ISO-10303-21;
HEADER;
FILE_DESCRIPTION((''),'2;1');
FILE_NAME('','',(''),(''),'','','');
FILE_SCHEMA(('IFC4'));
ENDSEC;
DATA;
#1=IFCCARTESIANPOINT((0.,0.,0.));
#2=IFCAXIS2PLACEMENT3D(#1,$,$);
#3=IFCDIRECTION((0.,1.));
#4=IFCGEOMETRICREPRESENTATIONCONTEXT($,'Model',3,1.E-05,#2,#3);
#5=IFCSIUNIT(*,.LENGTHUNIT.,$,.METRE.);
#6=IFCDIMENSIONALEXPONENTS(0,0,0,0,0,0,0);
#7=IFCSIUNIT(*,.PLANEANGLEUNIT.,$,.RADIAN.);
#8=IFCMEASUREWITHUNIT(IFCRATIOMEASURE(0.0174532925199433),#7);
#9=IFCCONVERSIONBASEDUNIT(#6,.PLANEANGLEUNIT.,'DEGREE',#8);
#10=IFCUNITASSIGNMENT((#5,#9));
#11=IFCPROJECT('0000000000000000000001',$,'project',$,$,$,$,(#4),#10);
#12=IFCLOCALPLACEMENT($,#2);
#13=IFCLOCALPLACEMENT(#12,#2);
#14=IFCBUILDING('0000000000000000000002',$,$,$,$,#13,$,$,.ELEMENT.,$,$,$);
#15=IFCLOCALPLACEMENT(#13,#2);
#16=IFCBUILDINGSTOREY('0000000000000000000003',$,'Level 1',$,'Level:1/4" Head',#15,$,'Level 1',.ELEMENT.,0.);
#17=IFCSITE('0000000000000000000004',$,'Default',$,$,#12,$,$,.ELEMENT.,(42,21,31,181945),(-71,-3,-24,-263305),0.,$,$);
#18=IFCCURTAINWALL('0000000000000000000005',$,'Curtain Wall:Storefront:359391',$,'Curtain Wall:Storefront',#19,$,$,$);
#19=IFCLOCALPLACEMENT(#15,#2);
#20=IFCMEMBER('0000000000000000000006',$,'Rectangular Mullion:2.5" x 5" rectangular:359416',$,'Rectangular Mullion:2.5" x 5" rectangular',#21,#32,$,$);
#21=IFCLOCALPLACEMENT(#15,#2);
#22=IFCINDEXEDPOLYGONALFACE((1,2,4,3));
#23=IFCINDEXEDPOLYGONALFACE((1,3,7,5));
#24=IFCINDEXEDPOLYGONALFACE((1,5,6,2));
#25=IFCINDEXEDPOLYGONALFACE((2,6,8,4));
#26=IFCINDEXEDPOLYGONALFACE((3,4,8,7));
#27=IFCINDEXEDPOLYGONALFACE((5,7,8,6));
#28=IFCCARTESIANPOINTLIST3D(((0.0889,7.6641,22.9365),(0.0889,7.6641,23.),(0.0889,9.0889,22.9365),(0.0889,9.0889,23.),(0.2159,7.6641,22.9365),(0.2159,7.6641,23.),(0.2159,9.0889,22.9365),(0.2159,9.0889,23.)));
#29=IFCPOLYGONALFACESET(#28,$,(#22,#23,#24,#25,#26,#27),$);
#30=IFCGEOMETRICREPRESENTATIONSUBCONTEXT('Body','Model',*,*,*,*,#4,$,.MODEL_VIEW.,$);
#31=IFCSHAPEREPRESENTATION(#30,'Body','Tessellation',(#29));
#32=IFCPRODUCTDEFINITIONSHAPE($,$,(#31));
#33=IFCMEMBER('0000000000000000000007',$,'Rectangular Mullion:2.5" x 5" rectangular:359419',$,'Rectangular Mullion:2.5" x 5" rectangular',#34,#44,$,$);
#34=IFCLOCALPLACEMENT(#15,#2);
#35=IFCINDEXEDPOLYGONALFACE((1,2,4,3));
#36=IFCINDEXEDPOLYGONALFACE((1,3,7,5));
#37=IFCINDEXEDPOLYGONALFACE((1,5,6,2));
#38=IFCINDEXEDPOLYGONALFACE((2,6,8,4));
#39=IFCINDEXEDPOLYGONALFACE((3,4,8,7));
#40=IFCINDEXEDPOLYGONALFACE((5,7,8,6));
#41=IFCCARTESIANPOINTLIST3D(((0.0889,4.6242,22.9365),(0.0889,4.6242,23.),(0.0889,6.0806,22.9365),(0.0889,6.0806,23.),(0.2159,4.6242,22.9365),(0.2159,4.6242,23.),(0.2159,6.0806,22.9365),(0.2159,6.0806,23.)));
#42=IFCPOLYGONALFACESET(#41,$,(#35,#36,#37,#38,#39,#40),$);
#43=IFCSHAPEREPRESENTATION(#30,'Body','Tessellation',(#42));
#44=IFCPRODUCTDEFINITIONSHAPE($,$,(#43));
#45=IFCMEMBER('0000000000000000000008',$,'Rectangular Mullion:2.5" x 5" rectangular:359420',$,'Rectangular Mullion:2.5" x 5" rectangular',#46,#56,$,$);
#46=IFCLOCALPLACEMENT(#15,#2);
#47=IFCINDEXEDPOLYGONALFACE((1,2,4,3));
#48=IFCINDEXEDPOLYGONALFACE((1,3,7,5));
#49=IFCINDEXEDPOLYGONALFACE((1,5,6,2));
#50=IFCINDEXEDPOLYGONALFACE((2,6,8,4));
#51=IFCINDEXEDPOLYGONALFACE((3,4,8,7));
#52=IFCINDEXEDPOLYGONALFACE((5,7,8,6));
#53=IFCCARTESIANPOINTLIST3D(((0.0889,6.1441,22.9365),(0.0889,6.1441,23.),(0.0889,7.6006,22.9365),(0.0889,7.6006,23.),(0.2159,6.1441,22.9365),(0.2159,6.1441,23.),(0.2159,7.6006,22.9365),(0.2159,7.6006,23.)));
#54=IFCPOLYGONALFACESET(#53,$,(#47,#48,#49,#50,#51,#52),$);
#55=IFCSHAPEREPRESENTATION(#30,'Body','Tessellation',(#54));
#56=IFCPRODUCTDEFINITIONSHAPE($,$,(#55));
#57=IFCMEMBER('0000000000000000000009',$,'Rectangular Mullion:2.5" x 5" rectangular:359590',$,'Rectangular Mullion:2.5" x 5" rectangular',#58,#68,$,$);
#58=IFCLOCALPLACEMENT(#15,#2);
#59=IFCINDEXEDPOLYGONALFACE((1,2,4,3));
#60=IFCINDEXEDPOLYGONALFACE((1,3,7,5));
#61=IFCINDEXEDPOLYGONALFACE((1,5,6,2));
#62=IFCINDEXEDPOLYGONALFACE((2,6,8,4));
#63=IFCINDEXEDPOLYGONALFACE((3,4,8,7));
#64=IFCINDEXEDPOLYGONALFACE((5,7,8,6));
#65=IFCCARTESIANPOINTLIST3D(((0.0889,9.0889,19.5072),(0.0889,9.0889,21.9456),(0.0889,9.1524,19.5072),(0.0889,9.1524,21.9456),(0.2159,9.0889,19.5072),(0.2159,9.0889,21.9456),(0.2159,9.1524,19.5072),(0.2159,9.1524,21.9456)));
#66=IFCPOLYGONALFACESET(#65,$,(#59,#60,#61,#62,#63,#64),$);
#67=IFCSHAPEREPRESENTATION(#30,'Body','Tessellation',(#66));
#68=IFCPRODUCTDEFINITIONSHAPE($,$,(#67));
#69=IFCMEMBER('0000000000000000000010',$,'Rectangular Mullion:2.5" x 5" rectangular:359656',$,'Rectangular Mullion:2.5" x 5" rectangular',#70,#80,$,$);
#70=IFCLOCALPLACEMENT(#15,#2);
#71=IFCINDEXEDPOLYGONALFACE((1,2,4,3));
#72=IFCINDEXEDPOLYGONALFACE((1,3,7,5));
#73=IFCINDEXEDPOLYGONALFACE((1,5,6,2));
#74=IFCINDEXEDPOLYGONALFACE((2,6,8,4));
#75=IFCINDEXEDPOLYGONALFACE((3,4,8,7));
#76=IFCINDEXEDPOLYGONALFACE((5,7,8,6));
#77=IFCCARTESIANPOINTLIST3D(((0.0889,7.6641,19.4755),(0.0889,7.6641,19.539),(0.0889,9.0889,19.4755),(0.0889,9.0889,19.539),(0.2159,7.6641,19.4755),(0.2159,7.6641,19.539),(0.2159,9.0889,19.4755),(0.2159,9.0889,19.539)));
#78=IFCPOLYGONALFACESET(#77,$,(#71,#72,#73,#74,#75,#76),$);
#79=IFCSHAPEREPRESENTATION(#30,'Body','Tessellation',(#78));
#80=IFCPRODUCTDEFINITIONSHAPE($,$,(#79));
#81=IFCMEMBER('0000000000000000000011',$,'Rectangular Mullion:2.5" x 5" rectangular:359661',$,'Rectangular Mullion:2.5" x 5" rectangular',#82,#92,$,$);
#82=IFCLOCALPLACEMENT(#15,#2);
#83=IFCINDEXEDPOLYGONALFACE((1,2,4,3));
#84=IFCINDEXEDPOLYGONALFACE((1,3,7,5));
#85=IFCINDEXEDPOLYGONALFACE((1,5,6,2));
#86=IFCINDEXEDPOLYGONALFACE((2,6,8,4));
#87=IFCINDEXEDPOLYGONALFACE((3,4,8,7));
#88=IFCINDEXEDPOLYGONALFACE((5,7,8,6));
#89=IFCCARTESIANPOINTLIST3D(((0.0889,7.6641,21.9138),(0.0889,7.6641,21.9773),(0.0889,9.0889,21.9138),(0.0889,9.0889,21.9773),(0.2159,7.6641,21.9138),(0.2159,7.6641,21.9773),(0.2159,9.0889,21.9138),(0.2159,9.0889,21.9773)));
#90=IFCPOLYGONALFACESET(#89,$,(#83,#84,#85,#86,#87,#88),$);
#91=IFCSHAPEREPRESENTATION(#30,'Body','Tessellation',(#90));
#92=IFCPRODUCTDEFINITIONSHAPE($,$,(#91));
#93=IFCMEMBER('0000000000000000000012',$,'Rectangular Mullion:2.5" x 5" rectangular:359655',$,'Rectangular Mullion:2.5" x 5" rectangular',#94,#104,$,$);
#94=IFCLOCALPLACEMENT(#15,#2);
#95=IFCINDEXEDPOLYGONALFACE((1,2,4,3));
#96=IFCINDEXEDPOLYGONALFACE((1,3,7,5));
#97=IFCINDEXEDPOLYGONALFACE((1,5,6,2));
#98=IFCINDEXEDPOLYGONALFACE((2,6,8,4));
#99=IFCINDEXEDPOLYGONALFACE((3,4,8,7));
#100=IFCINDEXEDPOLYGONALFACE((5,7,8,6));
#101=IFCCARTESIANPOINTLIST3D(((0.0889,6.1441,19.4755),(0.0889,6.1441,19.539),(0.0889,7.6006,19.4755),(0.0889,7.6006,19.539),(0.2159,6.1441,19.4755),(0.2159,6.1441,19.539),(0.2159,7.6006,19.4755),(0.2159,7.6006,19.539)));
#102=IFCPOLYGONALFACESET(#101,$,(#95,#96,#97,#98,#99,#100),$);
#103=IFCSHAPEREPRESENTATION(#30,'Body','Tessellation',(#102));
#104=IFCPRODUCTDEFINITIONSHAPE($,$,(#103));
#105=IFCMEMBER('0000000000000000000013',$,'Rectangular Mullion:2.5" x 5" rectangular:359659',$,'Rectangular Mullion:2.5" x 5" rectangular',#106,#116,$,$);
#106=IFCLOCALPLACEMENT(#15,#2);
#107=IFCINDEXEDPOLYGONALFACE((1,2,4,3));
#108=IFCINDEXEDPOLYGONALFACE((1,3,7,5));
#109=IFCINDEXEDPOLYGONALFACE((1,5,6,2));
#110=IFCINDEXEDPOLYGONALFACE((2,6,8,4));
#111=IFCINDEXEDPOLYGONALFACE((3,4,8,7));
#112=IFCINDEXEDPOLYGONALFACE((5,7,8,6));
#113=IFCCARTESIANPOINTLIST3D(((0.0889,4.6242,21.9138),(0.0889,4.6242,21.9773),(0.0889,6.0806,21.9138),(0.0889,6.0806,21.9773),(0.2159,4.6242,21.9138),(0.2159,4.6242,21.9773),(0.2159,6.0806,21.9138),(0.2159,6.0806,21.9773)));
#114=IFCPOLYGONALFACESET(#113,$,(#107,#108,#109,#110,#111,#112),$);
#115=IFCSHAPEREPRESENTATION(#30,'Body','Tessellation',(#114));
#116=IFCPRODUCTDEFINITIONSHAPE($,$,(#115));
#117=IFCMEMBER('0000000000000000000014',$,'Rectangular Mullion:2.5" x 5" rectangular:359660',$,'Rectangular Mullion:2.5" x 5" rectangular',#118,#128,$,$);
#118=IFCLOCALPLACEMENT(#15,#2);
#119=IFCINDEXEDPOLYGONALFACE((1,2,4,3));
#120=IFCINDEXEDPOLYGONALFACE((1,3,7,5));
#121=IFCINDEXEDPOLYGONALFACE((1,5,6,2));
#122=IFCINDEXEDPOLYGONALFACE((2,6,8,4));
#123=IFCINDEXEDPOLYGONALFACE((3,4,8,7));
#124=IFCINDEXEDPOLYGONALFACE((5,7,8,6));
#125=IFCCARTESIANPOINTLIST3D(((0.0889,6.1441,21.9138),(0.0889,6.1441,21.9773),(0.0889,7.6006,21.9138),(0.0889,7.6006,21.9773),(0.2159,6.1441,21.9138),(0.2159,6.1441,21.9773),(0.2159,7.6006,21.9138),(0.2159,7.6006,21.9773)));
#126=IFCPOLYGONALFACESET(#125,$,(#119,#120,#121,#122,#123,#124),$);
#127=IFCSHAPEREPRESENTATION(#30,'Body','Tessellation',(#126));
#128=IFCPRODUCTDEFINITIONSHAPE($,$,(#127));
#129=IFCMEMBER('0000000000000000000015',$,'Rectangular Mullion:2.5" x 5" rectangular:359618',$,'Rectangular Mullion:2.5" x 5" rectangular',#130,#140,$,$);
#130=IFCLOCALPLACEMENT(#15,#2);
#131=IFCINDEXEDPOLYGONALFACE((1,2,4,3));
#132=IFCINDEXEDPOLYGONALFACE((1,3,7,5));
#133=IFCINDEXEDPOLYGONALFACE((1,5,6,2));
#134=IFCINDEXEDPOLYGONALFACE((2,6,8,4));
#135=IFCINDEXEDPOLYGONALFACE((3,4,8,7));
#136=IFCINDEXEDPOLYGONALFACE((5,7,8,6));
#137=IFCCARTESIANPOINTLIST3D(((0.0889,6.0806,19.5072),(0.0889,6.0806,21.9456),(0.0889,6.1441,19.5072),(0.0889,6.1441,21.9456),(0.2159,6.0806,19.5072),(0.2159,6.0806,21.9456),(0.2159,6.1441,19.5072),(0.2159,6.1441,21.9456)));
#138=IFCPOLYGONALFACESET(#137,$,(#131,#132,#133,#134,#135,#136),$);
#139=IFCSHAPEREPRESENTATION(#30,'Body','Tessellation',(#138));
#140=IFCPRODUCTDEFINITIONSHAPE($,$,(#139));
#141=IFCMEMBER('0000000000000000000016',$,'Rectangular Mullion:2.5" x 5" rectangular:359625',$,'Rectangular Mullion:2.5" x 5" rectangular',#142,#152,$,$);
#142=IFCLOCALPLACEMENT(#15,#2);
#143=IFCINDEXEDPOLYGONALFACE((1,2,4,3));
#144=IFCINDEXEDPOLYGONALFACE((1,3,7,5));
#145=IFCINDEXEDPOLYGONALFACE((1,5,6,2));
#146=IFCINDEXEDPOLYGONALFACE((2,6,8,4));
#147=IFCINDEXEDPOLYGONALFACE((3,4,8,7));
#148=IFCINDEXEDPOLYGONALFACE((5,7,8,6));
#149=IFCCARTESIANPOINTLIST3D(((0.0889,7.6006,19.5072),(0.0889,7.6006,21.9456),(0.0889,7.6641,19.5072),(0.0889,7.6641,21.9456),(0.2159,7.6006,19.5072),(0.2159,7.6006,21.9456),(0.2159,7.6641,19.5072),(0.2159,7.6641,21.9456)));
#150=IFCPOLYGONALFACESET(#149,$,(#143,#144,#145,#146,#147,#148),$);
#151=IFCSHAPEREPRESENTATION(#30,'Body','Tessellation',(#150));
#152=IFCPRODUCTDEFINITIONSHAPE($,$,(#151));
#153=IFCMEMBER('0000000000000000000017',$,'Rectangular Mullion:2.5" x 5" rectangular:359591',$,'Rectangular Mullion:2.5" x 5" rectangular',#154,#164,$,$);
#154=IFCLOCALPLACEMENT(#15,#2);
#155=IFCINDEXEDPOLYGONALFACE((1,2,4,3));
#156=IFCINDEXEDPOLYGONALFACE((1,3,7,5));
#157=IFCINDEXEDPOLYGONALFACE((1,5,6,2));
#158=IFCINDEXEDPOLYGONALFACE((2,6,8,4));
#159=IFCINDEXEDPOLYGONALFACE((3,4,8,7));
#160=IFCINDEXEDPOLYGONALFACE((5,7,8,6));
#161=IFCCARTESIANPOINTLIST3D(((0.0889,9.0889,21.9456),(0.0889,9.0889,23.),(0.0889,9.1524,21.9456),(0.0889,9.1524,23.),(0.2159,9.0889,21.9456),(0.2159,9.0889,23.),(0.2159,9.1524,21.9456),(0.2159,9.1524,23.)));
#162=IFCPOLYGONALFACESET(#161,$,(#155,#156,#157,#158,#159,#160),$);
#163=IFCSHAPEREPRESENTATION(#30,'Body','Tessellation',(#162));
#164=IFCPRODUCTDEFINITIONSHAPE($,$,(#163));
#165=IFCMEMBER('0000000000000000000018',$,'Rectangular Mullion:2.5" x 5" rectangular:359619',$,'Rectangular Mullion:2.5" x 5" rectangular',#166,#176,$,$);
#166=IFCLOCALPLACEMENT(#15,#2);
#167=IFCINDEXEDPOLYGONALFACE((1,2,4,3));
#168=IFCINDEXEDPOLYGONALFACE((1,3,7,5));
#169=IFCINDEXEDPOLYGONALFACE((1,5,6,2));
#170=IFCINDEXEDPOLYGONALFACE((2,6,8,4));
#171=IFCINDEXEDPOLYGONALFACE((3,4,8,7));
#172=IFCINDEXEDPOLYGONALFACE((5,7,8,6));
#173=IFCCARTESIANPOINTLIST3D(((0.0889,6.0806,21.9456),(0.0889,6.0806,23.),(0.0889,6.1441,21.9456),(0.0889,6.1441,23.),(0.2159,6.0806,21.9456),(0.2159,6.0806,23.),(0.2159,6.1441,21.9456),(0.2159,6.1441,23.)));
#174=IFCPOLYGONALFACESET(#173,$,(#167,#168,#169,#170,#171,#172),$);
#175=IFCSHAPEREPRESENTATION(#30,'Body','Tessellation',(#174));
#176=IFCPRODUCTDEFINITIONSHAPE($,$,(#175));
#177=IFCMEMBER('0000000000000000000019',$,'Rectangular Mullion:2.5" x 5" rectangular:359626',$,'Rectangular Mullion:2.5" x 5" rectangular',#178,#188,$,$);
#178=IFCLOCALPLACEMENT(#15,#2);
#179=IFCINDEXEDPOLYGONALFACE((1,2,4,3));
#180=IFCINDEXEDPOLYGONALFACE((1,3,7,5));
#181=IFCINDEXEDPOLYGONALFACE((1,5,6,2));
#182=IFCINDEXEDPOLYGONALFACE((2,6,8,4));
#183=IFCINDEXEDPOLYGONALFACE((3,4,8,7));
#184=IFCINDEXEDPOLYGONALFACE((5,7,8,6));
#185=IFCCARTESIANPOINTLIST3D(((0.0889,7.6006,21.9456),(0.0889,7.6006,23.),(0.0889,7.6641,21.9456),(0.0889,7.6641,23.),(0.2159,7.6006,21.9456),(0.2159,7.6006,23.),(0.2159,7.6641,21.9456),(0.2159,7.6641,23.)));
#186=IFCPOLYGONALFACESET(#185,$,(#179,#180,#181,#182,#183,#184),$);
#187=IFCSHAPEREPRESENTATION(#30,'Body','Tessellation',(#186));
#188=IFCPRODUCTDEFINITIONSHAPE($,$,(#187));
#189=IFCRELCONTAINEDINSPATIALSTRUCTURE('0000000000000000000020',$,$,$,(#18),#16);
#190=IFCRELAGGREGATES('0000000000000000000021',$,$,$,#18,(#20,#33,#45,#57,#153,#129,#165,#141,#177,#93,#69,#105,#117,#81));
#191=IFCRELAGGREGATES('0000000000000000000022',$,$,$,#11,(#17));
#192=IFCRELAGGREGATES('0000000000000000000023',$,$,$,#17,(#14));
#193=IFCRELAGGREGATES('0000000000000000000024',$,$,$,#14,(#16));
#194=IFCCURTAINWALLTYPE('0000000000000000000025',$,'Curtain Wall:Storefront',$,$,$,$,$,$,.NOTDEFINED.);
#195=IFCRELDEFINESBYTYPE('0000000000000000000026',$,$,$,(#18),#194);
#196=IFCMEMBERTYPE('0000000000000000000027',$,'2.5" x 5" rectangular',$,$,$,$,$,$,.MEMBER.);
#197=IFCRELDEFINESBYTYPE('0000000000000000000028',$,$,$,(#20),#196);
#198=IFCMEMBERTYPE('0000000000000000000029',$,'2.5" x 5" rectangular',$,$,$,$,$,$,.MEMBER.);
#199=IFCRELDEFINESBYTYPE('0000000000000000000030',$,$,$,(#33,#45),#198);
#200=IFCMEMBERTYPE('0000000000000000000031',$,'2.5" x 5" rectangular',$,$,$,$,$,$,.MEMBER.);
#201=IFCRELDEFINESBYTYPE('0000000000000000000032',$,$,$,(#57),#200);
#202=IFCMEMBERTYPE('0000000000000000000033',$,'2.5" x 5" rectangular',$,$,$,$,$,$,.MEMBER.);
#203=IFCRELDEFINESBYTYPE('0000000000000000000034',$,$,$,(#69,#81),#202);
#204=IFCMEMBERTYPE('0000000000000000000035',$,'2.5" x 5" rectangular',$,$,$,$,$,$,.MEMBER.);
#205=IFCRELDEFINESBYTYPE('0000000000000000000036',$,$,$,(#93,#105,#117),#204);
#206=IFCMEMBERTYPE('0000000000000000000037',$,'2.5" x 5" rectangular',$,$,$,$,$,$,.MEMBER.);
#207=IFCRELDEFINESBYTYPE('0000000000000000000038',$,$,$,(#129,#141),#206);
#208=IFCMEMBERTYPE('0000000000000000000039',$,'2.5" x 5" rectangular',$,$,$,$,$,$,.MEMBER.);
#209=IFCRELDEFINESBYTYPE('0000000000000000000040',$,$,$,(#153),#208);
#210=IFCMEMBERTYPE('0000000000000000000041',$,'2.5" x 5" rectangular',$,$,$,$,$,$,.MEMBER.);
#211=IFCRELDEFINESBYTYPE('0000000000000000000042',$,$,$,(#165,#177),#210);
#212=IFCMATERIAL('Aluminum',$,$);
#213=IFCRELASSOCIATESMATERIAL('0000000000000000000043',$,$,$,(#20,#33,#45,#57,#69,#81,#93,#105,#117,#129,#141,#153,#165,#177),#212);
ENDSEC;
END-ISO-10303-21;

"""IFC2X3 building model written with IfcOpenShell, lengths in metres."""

from ifc_helpers import new_model, entity, si_unit, converted_unit, direction, frame, origin, origin_2d_with_axis, place, context, subcontext, project, spatial, rectangle, extrude, source, transform, mapped, material, type_object, type_shapes, element, aggregate, save


model = new_model("IFC2X3")

# Units and contexts
model_context = context("Model", 3, precision=1e-05, world=origin(), true_north=direction((0.0, 1.0)))
body_context = subcontext(model_context, "Body", "Model", "MODEL_VIEW")
ifc_project = project(units=[si_unit("LENGTHUNIT", "METRE"), converted_unit("PLANEANGLEUNIT", "DEGREE", entity("IfcRatioMeasure", 0.0174532925199433), si_unit("PLANEANGLEUNIT", "RADIAN"), dimensions=[0, 0, 0, 0, 0, 0, 0])], contexts=[model_context])

# Site, building, storey
site_placement = place(None, origin())
site = spatial("IfcSite", under=ifc_project, at=site_placement, Name="Default", CompositionType="ELEMENT", RefLatitude=(42, 21, 31, 181945), RefLongitude=(-71, -3, -24, -263305), RefElevation=0.0)
building_placement = place(site_placement, origin())
building = spatial("IfcBuilding", under=site, at=building_placement, CompositionType="ELEMENT")
storey_placement = place(building_placement, origin())
storey = spatial("IfcBuildingStorey", under=building, at=storey_placement, Name="Level 1", ObjectType="Level:1/4\" Head", LongName="Level 1", CompositionType="ELEMENT", Elevation=0.0)

# Curtain wall, members
curtain_wall_type = type_object("IfcCurtainWallType", Name="Curtain Wall:Storefront", PredefinedType="NOTDEFINED")
curtain_wall_placement = place(storey_placement, origin())
curtain_wall = element("IfcCurtainWall", 1, at=curtain_wall_placement, inside=storey, type_object=curtain_wall_type, Name="Curtain Wall:Storefront:359391", ObjectType="Curtain Wall:Storefront")
ifc_material_1 = material(Name="Aluminum")
member_type_1 = type_object("IfcMemberType", Name="2.5\" x 5\" rectangular", PredefinedType="MEMBER")
shared_shape_1 = source(origin(), body_context, "Body", "SweptSolid", [
    extrude(rectangle(XDim=0.127, YDim=0.0635, at=origin_2d_with_axis()), frame((-0.0318, 0.0, -1.4248), z_axis=(0.0, 0.0, 1.0), x_axis=(0.0, -1.0, 0.0)), (0.0, 0.0, 1.0), 1.4248),
])
type_shapes(member_type_1, [shared_shape_1])
member_1_placement = place(storey_placement, frame((0.1524, 9.0889, 23.0), z_axis=(0.0, 1.0, 0.0), x_axis=(0.0, 0.0, 1.0)))
member_1 = element("IfcMember", 2, at=member_1_placement, type_object=member_type_1, material=ifc_material_1, Name="Rectangular Mullion:2.5\" x 5\" rectangular:359416", ObjectType="Rectangular Mullion:2.5\" x 5\" rectangular", context=body_context, shape_type="MappedRepresentation", body=[
    mapped(shared_shape_1, transform((0.0, 0.0, 0.0), scale=1.0)),
])
member_type_2 = type_object("IfcMemberType", Name="2.5\" x 5\" rectangular", PredefinedType="MEMBER")
shared_shape_2 = source(origin(), body_context, "Body", "SweptSolid", [
    extrude(rectangle(XDim=0.127, YDim=0.0635, at=origin_2d_with_axis()), frame((-0.0318, 0.0, -1.4565), z_axis=(0.0, 0.0, 1.0), x_axis=(0.0, -1.0, 0.0)), (0.0, 0.0, 1.0), 1.4565),
])
type_shapes(member_type_2, [shared_shape_2])
member_2_placement = place(storey_placement, frame((0.1524, 6.0806, 23.0), z_axis=(0.0, 1.0, 0.0), x_axis=(0.0, 0.0, 1.0)))
member_2 = element("IfcMember", 3, at=member_2_placement, type_object=member_type_2, material=ifc_material_1, Name="Rectangular Mullion:2.5\" x 5\" rectangular:359419", ObjectType="Rectangular Mullion:2.5\" x 5\" rectangular", context=body_context, shape_type="MappedRepresentation", body=[
    mapped(shared_shape_2, transform((0.0, 0.0, 0.0), scale=1.0)),
])
member_3_placement = place(storey_placement, frame((0.1524, 7.6006, 23.0), z_axis=(0.0, 1.0, 0.0), x_axis=(0.0, 0.0, 1.0)))
member_3 = element("IfcMember", 4, at=member_3_placement, type_object=member_type_2, material=ifc_material_1, Name="Rectangular Mullion:2.5\" x 5\" rectangular:359420", ObjectType="Rectangular Mullion:2.5\" x 5\" rectangular", context=body_context, shape_type="MappedRepresentation", body=[
    mapped(shared_shape_2, transform((0.0, 0.0, 0.0), scale=1.0)),
])
member_type_3 = type_object("IfcMemberType", Name="2.5\" x 5\" rectangular", PredefinedType="MEMBER")
shared_shape_3 = source(origin(), body_context, "Body", "SweptSolid", [
    extrude(rectangle(XDim=0.127, YDim=0.0635, at=origin_2d_with_axis()), frame((-0.0318, 0.0, -2.4384), z_axis=(0.0, 0.0, 1.0), x_axis=(0.0, -1.0, 0.0)), (0.0, 0.0, 1.0), 2.4384),
])
type_shapes(member_type_3, [shared_shape_3])
member_4_placement = place(storey_placement, frame((0.1524, 9.1524, 19.5072), z_axis=(0.0, 0.0, -1.0), x_axis=(0.0, 1.0, 0.0)))
member_4 = element("IfcMember", 5, at=member_4_placement, type_object=member_type_3, material=ifc_material_1, Name="Rectangular Mullion:2.5\" x 5\" rectangular:359590", ObjectType="Rectangular Mullion:2.5\" x 5\" rectangular", context=body_context, shape_type="MappedRepresentation", body=[
    mapped(shared_shape_3, transform((0.0, 0.0, 0.0), scale=1.0)),
])
member_type_4 = type_object("IfcMemberType", Name="2.5\" x 5\" rectangular", PredefinedType="MEMBER")
shared_shape_4 = source(origin(), body_context, "Body", "SweptSolid", [
    extrude(rectangle(XDim=0.127, YDim=0.0635, at=origin_2d_with_axis()), frame((0.0, 0.0, -1.4248), z_axis=(0.0, 0.0, 1.0), x_axis=(0.0, -1.0, 0.0)), (0.0, 0.0, 1.0), 1.4248),
])
type_shapes(member_type_4, [shared_shape_4])
member_5_placement = place(storey_placement, frame((0.1524, 9.0889, 19.5072), z_axis=(0.0, 1.0, 0.0), x_axis=(0.0, 0.0, 1.0)))
member_5 = element("IfcMember", 6, at=member_5_placement, type_object=member_type_4, material=ifc_material_1, Name="Rectangular Mullion:2.5\" x 5\" rectangular:359656", ObjectType="Rectangular Mullion:2.5\" x 5\" rectangular", context=body_context, shape_type="MappedRepresentation", body=[
    mapped(shared_shape_4, transform((0.0, 0.0, 0.0), scale=1.0)),
])
member_6_placement = place(storey_placement, frame((0.1524, 9.0889, 21.9456), z_axis=(0.0, 1.0, 0.0), x_axis=(0.0, 0.0, 1.0)))
member_6 = element("IfcMember", 7, at=member_6_placement, type_object=member_type_4, material=ifc_material_1, Name="Rectangular Mullion:2.5\" x 5\" rectangular:359661", ObjectType="Rectangular Mullion:2.5\" x 5\" rectangular", context=body_context, shape_type="MappedRepresentation", body=[
    mapped(shared_shape_4, transform((0.0, 0.0, 0.0), scale=1.0)),
])
member_type_5 = type_object("IfcMemberType", Name="2.5\" x 5\" rectangular", PredefinedType="MEMBER")
shared_shape_5 = source(origin(), body_context, "Body", "SweptSolid", [
    extrude(rectangle(XDim=0.127, YDim=0.0635, at=origin_2d_with_axis()), frame((0.0, 0.0, -1.4565), z_axis=(0.0, 0.0, 1.0), x_axis=(0.0, -1.0, 0.0)), (0.0, 0.0, 1.0), 1.4565),
])
type_shapes(member_type_5, [shared_shape_5])
member_7_placement = place(storey_placement, frame((0.1524, 7.6006, 19.5072), z_axis=(0.0, 1.0, 0.0), x_axis=(0.0, 0.0, 1.0)))
member_7 = element("IfcMember", 8, at=member_7_placement, type_object=member_type_5, material=ifc_material_1, Name="Rectangular Mullion:2.5\" x 5\" rectangular:359655", ObjectType="Rectangular Mullion:2.5\" x 5\" rectangular", context=body_context, shape_type="MappedRepresentation", body=[
    mapped(shared_shape_5, transform((0.0, 0.0, 0.0), scale=1.0)),
])
member_8_placement = place(storey_placement, frame((0.1524, 6.0806, 21.9456), z_axis=(0.0, 1.0, 0.0), x_axis=(0.0, 0.0, 1.0)))
member_8 = element("IfcMember", 9, at=member_8_placement, type_object=member_type_5, material=ifc_material_1, Name="Rectangular Mullion:2.5\" x 5\" rectangular:359659", ObjectType="Rectangular Mullion:2.5\" x 5\" rectangular", context=body_context, shape_type="MappedRepresentation", body=[
    mapped(shared_shape_5, transform((0.0, 0.0, 0.0), scale=1.0)),
])
member_9_placement = place(storey_placement, frame((0.1524, 7.6006, 21.9456), z_axis=(0.0, 1.0, 0.0), x_axis=(0.0, 0.0, 1.0)))
member_9 = element("IfcMember", 10, at=member_9_placement, type_object=member_type_5, material=ifc_material_1, Name="Rectangular Mullion:2.5\" x 5\" rectangular:359660", ObjectType="Rectangular Mullion:2.5\" x 5\" rectangular", context=body_context, shape_type="MappedRepresentation", body=[
    mapped(shared_shape_5, transform((0.0, 0.0, 0.0), scale=1.0)),
])
member_type_6 = type_object("IfcMemberType", Name="2.5\" x 5\" rectangular", PredefinedType="MEMBER")
shared_shape_6 = source(origin(), body_context, "Body", "SweptSolid", [
    extrude(rectangle(XDim=0.127, YDim=0.0635, at=origin_2d_with_axis()), frame((0.0, 0.0, -2.4384), z_axis=(0.0, 0.0, 1.0), x_axis=(0.0, -1.0, 0.0)), (0.0, 0.0, 1.0), 2.4384),
])
type_shapes(member_type_6, [shared_shape_6])
member_10_placement = place(storey_placement, frame((0.1524, 6.1124, 19.5072), z_axis=(0.0, 0.0, -1.0), x_axis=(0.0, 1.0, 0.0)))
member_10 = element("IfcMember", 11, at=member_10_placement, type_object=member_type_6, material=ifc_material_1, Name="Rectangular Mullion:2.5\" x 5\" rectangular:359618", ObjectType="Rectangular Mullion:2.5\" x 5\" rectangular", context=body_context, shape_type="MappedRepresentation", body=[
    mapped(shared_shape_6, transform((0.0, 0.0, 0.0), scale=1.0)),
])
member_11_placement = place(storey_placement, frame((0.1524, 7.6324, 19.5072), z_axis=(0.0, 0.0, -1.0), x_axis=(0.0, 1.0, 0.0)))
member_11 = element("IfcMember", 12, at=member_11_placement, type_object=member_type_6, material=ifc_material_1, Name="Rectangular Mullion:2.5\" x 5\" rectangular:359625", ObjectType="Rectangular Mullion:2.5\" x 5\" rectangular", context=body_context, shape_type="MappedRepresentation", body=[
    mapped(shared_shape_6, transform((0.0, 0.0, 0.0), scale=1.0)),
])
member_type_7 = type_object("IfcMemberType", Name="2.5\" x 5\" rectangular", PredefinedType="MEMBER")
shared_shape_7 = source(origin(), body_context, "Body", "SweptSolid", [
    extrude(rectangle(XDim=0.127, YDim=0.0635, at=origin_2d_with_axis()), frame((-0.0318, 0.0, -1.0544), z_axis=(0.0, 0.0, 1.0), x_axis=(0.0, -1.0, 0.0)), (0.0, 0.0, 1.0), 1.0544),
])
type_shapes(member_type_7, [shared_shape_7])
member_12_placement = place(storey_placement, frame((0.1524, 9.1524, 21.9456), z_axis=(0.0, 0.0, -1.0), x_axis=(0.0, 1.0, 0.0)))
member_12 = element("IfcMember", 13, at=member_12_placement, type_object=member_type_7, material=ifc_material_1, Name="Rectangular Mullion:2.5\" x 5\" rectangular:359591", ObjectType="Rectangular Mullion:2.5\" x 5\" rectangular", context=body_context, shape_type="MappedRepresentation", body=[
    mapped(shared_shape_7, transform((0.0, 0.0, 0.0), scale=1.0)),
])
member_type_8 = type_object("IfcMemberType", Name="2.5\" x 5\" rectangular", PredefinedType="MEMBER")
shared_shape_8 = source(origin(), body_context, "Body", "SweptSolid", [
    extrude(rectangle(XDim=0.127, YDim=0.0635, at=origin_2d_with_axis()), frame((0.0, 0.0, -1.0544), z_axis=(0.0, 0.0, 1.0), x_axis=(0.0, -1.0, 0.0)), (0.0, 0.0, 1.0), 1.0544),
])
type_shapes(member_type_8, [shared_shape_8])
member_13_placement = place(storey_placement, frame((0.1524, 6.1124, 21.9456), z_axis=(0.0, 0.0, -1.0), x_axis=(0.0, 1.0, 0.0)))
member_13 = element("IfcMember", 14, at=member_13_placement, type_object=member_type_8, material=ifc_material_1, Name="Rectangular Mullion:2.5\" x 5\" rectangular:359619", ObjectType="Rectangular Mullion:2.5\" x 5\" rectangular", context=body_context, shape_type="MappedRepresentation", body=[
    mapped(shared_shape_8, transform((0.0, 0.0, 0.0), scale=1.0)),
])
member_14_placement = place(storey_placement, frame((0.1524, 7.6324, 21.9456), z_axis=(0.0, 0.0, -1.0), x_axis=(0.0, 1.0, 0.0)))
member_14 = element("IfcMember", 15, at=member_14_placement, type_object=member_type_8, material=ifc_material_1, Name="Rectangular Mullion:2.5\" x 5\" rectangular:359626", ObjectType="Rectangular Mullion:2.5\" x 5\" rectangular", context=body_context, shape_type="MappedRepresentation", body=[
    mapped(shared_shape_8, transform((0.0, 0.0, 0.0), scale=1.0)),
])
aggregate(curtain_wall, [member_1, member_2, member_3, member_4, member_12, member_10, member_13, member_11, member_14, member_7, member_5, member_8, member_9, member_6])

save(model, "model.ifc")
